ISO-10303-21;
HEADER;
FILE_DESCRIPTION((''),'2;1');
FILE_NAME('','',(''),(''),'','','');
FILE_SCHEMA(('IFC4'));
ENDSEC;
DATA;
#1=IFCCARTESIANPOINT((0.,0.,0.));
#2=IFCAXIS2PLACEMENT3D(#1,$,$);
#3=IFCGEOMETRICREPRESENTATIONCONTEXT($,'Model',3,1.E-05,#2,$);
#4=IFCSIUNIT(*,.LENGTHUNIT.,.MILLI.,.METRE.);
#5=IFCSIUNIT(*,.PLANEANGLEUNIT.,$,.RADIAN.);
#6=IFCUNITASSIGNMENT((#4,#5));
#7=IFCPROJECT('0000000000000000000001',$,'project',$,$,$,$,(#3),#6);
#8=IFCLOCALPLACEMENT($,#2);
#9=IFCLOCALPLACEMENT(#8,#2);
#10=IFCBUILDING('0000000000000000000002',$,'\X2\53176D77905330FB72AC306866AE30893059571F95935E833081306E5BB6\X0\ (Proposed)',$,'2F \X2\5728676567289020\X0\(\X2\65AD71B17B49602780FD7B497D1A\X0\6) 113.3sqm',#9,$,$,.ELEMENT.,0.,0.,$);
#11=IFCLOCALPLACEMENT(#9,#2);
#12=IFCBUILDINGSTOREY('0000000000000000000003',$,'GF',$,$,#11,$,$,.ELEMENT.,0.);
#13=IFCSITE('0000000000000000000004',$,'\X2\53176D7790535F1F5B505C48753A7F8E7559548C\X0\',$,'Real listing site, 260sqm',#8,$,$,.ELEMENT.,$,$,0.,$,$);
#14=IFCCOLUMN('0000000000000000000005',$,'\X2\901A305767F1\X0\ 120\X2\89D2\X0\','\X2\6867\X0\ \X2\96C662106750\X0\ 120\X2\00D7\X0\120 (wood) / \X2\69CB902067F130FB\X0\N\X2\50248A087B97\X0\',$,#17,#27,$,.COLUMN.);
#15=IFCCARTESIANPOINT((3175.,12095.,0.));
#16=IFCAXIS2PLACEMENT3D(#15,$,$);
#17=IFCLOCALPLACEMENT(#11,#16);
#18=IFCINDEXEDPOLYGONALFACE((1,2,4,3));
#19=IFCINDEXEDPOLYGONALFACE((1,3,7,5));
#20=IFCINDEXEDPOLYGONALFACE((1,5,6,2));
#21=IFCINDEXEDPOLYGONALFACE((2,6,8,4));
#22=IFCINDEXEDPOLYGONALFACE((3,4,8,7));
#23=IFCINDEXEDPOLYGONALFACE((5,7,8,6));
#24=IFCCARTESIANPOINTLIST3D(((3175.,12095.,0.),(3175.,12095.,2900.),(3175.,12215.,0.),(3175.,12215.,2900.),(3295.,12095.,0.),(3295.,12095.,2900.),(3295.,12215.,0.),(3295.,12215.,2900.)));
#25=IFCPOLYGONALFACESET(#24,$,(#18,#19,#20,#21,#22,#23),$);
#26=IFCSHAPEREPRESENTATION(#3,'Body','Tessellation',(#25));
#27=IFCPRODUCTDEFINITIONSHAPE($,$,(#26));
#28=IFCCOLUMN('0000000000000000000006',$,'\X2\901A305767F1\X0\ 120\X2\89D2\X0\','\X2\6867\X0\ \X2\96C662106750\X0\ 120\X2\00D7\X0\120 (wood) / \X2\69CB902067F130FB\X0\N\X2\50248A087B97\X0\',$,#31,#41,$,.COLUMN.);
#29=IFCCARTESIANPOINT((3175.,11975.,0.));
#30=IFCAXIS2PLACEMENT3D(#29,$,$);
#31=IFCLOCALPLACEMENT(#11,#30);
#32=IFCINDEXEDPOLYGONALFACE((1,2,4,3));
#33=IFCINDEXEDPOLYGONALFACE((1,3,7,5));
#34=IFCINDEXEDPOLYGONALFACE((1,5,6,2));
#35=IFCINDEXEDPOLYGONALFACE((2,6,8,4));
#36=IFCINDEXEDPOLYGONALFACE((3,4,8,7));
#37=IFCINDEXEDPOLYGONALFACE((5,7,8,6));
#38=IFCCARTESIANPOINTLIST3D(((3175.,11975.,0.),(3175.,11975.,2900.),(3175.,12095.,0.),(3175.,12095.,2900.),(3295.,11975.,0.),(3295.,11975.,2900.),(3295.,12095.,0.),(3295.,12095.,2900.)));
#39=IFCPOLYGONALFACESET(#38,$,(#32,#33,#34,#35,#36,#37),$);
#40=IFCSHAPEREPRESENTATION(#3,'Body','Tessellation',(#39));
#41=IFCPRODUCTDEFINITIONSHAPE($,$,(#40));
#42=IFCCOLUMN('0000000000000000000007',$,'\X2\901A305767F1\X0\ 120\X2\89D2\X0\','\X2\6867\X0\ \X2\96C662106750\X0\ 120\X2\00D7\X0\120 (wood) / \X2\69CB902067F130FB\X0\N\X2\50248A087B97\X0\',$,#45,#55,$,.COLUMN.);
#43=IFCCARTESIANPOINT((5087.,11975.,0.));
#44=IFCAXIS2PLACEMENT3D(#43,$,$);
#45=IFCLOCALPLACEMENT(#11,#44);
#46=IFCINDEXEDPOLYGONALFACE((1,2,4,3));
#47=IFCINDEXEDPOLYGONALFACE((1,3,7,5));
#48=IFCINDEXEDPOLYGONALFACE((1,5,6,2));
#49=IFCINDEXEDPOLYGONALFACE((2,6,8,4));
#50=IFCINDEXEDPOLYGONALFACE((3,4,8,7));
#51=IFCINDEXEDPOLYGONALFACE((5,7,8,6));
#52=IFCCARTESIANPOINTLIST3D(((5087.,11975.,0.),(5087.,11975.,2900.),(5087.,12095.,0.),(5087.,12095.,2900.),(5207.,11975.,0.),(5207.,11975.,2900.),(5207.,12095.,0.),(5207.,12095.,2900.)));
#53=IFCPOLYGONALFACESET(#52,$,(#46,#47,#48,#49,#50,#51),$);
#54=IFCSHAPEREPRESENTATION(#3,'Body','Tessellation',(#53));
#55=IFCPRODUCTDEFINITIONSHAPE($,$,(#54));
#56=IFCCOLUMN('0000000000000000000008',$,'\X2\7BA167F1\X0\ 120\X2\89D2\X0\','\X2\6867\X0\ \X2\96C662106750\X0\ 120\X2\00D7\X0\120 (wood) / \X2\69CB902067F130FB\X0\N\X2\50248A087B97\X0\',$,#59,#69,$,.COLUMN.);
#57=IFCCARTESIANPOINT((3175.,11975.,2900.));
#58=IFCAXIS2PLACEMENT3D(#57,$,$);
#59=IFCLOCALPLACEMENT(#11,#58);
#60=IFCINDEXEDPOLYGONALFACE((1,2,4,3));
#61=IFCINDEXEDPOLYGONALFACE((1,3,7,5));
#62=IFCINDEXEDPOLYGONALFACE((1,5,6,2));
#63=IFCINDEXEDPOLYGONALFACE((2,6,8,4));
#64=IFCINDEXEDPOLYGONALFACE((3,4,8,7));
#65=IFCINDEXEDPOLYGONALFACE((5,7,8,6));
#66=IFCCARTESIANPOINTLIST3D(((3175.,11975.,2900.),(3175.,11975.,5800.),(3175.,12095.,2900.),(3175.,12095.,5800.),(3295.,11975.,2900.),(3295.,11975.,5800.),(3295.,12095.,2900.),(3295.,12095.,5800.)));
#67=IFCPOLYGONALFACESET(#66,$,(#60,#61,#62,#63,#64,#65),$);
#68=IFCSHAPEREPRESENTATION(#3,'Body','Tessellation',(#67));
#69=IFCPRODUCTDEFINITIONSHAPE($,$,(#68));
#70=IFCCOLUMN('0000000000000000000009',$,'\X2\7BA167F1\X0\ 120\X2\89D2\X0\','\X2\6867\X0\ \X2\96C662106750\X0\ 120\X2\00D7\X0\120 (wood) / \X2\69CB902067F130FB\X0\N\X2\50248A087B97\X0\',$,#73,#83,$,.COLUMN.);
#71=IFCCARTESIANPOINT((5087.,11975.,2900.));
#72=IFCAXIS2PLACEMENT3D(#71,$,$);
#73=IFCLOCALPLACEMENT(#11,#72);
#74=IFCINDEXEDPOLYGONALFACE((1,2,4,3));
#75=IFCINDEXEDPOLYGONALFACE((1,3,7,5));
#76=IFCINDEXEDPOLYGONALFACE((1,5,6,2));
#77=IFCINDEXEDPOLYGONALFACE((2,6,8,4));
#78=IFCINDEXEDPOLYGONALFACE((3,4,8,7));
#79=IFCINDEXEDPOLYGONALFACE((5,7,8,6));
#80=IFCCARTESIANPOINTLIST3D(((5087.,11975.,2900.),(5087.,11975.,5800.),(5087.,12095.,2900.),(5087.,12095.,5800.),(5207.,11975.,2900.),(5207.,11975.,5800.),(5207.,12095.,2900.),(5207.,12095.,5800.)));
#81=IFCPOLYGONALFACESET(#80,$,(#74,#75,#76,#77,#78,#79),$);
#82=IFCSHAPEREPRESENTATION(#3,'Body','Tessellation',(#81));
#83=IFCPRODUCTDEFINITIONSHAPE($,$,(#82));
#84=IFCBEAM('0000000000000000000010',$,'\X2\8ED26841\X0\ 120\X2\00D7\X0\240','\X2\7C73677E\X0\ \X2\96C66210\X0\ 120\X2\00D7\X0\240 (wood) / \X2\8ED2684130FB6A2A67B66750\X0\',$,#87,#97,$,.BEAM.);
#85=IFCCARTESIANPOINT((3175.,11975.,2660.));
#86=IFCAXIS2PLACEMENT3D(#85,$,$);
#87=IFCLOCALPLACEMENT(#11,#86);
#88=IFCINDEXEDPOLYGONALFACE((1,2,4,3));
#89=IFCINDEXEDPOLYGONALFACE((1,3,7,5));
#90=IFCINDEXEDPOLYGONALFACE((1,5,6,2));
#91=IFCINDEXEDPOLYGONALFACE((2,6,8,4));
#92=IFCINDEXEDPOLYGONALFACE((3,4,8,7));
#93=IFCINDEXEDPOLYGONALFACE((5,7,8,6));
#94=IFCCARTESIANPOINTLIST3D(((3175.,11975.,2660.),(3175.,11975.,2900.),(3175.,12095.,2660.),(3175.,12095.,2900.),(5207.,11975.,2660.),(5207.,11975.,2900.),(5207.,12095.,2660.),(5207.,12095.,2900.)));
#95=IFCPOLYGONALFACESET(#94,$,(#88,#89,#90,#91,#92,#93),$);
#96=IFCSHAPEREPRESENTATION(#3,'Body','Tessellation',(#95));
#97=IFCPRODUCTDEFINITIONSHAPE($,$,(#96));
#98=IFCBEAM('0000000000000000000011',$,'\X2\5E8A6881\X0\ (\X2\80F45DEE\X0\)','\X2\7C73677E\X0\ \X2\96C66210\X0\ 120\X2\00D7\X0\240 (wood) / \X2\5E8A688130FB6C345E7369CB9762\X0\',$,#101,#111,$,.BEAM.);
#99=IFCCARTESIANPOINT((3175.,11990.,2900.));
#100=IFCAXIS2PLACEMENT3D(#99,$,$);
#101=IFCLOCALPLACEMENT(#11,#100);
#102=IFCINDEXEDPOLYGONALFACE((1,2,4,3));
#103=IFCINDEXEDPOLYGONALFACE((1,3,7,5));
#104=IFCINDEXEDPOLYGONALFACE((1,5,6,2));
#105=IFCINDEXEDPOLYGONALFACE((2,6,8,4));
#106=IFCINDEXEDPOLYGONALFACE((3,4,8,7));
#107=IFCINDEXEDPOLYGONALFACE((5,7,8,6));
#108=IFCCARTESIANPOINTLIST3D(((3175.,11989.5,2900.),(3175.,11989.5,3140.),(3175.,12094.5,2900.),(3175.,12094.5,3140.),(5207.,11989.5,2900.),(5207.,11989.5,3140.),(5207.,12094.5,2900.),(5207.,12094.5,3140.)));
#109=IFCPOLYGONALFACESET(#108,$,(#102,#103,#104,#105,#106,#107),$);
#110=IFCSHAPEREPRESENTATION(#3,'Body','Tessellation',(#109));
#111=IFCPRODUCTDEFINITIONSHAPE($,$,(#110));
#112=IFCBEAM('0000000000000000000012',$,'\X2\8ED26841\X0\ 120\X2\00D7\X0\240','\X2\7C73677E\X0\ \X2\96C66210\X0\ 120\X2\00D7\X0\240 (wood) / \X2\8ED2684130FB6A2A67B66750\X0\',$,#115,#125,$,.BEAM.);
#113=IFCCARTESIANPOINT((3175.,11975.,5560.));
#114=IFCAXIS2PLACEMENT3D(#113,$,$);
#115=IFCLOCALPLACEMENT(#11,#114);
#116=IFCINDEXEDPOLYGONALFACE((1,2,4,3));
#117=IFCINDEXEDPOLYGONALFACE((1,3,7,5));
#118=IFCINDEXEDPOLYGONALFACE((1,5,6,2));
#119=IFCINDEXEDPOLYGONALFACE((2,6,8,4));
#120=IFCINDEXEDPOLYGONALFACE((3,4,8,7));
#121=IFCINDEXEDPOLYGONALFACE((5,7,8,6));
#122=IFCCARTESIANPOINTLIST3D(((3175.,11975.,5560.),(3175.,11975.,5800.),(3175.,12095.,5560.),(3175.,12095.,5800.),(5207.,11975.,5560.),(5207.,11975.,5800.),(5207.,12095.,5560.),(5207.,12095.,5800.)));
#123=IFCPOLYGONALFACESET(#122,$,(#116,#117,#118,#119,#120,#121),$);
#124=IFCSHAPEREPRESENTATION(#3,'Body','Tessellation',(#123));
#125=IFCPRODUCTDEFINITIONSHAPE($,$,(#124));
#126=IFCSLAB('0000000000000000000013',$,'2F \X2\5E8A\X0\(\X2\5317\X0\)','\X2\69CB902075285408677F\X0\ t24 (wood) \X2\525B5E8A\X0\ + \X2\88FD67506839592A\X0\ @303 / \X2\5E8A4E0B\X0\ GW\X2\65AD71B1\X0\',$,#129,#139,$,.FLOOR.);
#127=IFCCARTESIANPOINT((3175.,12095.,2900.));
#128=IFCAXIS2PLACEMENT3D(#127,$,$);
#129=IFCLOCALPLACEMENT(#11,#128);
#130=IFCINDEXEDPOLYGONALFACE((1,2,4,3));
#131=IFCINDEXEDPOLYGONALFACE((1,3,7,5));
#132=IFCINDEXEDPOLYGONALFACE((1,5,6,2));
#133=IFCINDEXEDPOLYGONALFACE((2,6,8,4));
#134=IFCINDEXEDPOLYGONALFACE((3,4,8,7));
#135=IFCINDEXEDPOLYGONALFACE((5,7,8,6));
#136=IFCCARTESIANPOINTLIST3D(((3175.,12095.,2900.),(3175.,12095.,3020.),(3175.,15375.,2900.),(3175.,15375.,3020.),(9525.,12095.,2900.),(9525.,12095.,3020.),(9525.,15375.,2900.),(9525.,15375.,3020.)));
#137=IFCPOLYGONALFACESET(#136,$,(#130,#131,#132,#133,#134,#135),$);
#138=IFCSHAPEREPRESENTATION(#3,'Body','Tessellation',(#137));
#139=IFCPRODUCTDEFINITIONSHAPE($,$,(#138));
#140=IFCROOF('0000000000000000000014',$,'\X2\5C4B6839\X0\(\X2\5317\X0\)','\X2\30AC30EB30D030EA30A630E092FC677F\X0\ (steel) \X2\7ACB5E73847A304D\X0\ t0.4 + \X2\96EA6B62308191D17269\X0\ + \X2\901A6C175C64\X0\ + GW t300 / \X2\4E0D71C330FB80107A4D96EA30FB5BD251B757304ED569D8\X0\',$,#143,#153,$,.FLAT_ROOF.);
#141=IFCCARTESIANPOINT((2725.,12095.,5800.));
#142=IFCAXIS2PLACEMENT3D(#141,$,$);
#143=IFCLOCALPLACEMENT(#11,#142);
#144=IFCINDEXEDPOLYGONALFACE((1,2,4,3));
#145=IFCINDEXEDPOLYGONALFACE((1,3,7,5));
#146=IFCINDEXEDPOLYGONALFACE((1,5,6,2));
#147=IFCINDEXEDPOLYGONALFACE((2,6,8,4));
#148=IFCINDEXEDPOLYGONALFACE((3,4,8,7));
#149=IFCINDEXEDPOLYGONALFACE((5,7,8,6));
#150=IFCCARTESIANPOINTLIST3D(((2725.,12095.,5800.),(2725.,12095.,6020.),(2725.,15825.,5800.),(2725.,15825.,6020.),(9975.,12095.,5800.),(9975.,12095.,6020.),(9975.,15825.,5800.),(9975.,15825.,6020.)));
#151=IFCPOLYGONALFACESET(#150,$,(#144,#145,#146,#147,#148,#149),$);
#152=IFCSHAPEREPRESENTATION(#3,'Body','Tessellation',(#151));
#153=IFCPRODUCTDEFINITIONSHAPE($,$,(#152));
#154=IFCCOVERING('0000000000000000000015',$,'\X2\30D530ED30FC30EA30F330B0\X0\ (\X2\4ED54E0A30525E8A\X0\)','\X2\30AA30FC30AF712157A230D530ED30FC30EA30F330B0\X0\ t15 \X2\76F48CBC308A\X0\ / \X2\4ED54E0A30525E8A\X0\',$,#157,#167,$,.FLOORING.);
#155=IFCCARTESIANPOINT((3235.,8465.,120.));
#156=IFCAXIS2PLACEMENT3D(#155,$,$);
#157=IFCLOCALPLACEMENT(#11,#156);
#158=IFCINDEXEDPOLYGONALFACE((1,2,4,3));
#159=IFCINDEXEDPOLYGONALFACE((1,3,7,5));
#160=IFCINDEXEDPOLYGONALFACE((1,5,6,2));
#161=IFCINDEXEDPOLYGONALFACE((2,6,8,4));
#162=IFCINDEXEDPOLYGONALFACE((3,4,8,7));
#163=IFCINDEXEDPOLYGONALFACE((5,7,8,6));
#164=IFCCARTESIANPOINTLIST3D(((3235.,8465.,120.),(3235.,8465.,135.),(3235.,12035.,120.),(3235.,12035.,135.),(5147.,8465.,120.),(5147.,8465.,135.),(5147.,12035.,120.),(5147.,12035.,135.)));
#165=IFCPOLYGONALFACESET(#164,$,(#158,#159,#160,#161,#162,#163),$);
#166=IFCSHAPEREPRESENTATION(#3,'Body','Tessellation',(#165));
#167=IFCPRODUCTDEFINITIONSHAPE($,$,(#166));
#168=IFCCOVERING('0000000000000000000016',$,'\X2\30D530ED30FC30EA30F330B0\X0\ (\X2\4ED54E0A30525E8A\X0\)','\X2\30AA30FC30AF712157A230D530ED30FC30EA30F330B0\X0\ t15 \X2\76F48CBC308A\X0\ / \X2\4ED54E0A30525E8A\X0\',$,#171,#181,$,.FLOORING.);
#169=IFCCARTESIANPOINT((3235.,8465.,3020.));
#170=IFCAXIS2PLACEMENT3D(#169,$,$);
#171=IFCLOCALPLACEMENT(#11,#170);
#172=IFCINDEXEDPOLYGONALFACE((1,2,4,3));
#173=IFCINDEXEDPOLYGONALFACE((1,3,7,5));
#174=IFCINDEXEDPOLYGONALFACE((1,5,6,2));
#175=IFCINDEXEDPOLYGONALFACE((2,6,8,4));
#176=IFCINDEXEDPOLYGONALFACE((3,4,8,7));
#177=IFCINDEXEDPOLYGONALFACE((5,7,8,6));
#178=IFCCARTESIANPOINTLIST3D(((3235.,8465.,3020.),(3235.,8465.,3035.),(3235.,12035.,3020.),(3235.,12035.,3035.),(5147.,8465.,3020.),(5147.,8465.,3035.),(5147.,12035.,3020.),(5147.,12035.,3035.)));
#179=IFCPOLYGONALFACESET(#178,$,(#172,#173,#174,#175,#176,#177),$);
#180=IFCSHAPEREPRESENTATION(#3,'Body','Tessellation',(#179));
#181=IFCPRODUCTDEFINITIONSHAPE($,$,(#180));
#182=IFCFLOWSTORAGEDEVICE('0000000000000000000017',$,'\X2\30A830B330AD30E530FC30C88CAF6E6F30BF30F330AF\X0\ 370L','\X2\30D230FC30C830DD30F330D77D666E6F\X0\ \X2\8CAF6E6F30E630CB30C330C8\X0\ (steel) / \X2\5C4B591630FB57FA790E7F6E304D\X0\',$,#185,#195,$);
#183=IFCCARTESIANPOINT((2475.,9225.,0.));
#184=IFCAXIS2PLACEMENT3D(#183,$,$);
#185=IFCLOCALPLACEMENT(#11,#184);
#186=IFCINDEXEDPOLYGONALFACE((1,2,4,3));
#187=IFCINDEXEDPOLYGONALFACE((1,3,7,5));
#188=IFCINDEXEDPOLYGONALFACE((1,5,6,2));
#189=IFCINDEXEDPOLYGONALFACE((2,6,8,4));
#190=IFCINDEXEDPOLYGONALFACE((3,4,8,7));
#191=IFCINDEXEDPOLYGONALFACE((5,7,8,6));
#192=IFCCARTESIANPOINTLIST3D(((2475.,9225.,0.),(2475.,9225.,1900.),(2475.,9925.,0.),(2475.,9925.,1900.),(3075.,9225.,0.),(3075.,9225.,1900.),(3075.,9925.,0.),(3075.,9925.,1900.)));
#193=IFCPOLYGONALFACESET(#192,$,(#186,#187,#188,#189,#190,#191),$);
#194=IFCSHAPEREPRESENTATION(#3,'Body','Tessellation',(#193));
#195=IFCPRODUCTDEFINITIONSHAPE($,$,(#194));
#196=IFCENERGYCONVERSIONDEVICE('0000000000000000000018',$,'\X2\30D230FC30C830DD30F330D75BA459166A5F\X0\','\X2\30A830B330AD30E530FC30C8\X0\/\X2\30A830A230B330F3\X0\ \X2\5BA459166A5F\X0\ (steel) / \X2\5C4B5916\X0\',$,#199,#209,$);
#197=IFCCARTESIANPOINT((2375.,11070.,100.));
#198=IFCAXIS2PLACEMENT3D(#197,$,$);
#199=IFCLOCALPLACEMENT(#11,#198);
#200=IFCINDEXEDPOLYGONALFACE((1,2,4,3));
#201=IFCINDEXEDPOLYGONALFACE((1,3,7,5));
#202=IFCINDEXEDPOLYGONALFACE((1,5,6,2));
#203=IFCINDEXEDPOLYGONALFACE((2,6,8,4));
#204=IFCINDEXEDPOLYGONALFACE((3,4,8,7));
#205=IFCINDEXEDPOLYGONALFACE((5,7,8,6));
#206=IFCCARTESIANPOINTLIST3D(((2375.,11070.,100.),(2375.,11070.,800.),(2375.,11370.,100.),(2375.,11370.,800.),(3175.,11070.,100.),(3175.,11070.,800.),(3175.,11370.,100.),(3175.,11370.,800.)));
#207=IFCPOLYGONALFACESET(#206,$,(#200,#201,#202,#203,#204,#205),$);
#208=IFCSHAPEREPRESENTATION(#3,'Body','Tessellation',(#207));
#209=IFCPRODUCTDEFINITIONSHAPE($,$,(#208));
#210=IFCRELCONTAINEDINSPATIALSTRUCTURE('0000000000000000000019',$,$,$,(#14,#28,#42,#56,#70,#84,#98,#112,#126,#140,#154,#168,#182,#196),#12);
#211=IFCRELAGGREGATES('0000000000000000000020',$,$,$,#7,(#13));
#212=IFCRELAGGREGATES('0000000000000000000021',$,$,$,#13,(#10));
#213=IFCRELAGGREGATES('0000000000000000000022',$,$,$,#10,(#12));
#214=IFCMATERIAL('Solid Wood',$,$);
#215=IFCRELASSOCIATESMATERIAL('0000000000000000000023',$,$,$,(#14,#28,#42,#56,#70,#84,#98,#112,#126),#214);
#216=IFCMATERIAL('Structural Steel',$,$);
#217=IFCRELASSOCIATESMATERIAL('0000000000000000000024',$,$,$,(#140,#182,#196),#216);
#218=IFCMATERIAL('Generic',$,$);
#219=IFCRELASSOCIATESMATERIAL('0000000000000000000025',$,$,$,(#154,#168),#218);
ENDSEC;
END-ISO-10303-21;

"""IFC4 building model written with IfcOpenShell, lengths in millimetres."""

from ifc_helpers import new_model, si_unit, frame, frame_2d, origin, place, context, project, spatial, rectangle, extrude, material, element, save


model = new_model("IFC4")

# Units and contexts
model_context = context("Model", 3, precision=1e-05, world=origin())
ifc_project = project(units=[si_unit("LENGTHUNIT", "METRE", prefix="MILLI"), si_unit("PLANEANGLEUNIT", "RADIAN")], contexts=[model_context])

# Site, building, storey
site_placement = place(None, origin())
site = spatial("IfcSite", under=ifc_project, at=site_placement, Name="北海道弟子屈町美留和", ObjectType="Real listing site, 260sqm", CompositionType="ELEMENT", RefElevation=0.0)
building_placement = place(site_placement, origin())
building = spatial("IfcBuilding", under=site, at=building_placement, Name="北海道・犬と暮らす土間広めの家 (Proposed)", ObjectType="2F 在来木造(断熱等性能等級6) 113.3sqm", CompositionType="ELEMENT", ElevationOfRefHeight=0.0, ElevationOfTerrain=0.0)
storey_placement = place(building_placement, origin())
storey = spatial("IfcBuildingStorey", under=building, at=storey_placement, Name="GF", CompositionType="ELEMENT", Elevation=0.0)

# Columns
ifc_material_1 = material(Name="Solid Wood")
column_1_placement = place(storey_placement, frame((3175.0, 12095.0, 0.0)))
element("IfcColumn", 1, at=column_1_placement, inside=storey, material=ifc_material_1, Name="通し柱 120角", Description="桧 集成材 120×120 (wood) / 構造柱・N値計算", PredefinedType="COLUMN", context=model_context, shape_type="SweptSolid", body=[
    extrude(rectangle(XDim=120.0, YDim=120.0, at=frame_2d((60.0, 60.0))), frame((3175.0, 12095.0, 0.0)), (0.0, 0.0, 1.0), 2900.0),
])
column_2_placement = place(storey_placement, frame((3175.0, 11975.0, 0.0)))
element("IfcColumn", 2, at=column_2_placement, inside=storey, material=ifc_material_1, Name="通し柱 120角", Description="桧 集成材 120×120 (wood) / 構造柱・N値計算", PredefinedType="COLUMN", context=model_context, shape_type="SweptSolid", body=[
    extrude(rectangle(XDim=120.0, YDim=120.0, at=frame_2d((60.0, 60.0))), frame((3175.0, 11975.0, 0.0)), (0.0, 0.0, 1.0), 2900.0),
])
column_3_placement = place(storey_placement, frame((5087.0, 11975.0, 0.0)))
element("IfcColumn", 3, at=column_3_placement, inside=storey, material=ifc_material_1, Name="通し柱 120角", Description="桧 集成材 120×120 (wood) / 構造柱・N値計算", PredefinedType="COLUMN", context=model_context, shape_type="SweptSolid", body=[
    extrude(rectangle(XDim=120.0, YDim=120.0, at=frame_2d((60.0, 60.0))), frame((5087.0, 11975.0, 0.0)), (0.0, 0.0, 1.0), 2900.0),
])
column_4_placement = place(storey_placement, frame((3175.0, 11975.0, 2900.0)))
element("IfcColumn", 4, at=column_4_placement, inside=storey, material=ifc_material_1, Name="管柱 120角", Description="桧 集成材 120×120 (wood) / 構造柱・N値計算", PredefinedType="COLUMN", context=model_context, shape_type="SweptSolid", body=[
    extrude(rectangle(XDim=120.0, YDim=120.0, at=frame_2d((60.0, 60.0))), frame((3175.0, 11975.0, 2900.0)), (0.0, 0.0, 1.0), 2900.0),
])
column_5_placement = place(storey_placement, frame((5087.0, 11975.0, 2900.0)))
element("IfcColumn", 5, at=column_5_placement, inside=storey, material=ifc_material_1, Name="管柱 120角", Description="桧 集成材 120×120 (wood) / 構造柱・N値計算", PredefinedType="COLUMN", context=model_context, shape_type="SweptSolid", body=[
    extrude(rectangle(XDim=120.0, YDim=120.0, at=frame_2d((60.0, 60.0))), frame((5087.0, 11975.0, 2900.0)), (0.0, 0.0, 1.0), 2900.0),
])

# Beams
beam_1_placement = place(storey_placement, frame((3175.0, 11975.0, 2660.0)))
element("IfcBeam", 6, at=beam_1_placement, inside=storey, material=ifc_material_1, Name="軒桁 120×240", Description="米松 集成 120×240 (wood) / 軒桁・横架材", PredefinedType="BEAM", context=model_context, shape_type="SweptSolid", body=[
    extrude(rectangle(XDim=2032.0, YDim=120.0, at=frame_2d((1016.0, 60.0))), frame((3175.0, 11975.0, 2660.0)), (0.0, 0.0, 1.0), 240.0),
])
beam_2_placement = place(storey_placement, frame((3175.0, 11990.0, 2900.0)))
element("IfcBeam", 7, at=beam_2_placement, inside=storey, material=ifc_material_1, Name="床梁 (胴差)", Description="米松 集成 120×240 (wood) / 床梁・水平構面", PredefinedType="BEAM", context=model_context, shape_type="SweptSolid", body=[
    extrude(rectangle(XDim=2032.0, YDim=105.0, at=frame_2d((1016.0, 52.0))), frame((3175.0, 11990.0, 2900.0)), (0.0, 0.0, 1.0), 240.0),
])
beam_3_placement = place(storey_placement, frame((3175.0, 11975.0, 5560.0)))
element("IfcBeam", 8, at=beam_3_placement, inside=storey, material=ifc_material_1, Name="軒桁 120×240", Description="米松 集成 120×240 (wood) / 軒桁・横架材", PredefinedType="BEAM", context=model_context, shape_type="SweptSolid", body=[
    extrude(rectangle(XDim=2032.0, YDim=120.0, at=frame_2d((1016.0, 60.0))), frame((3175.0, 11975.0, 5560.0)), (0.0, 0.0, 1.0), 240.0),
])

# Slab
slab_1_placement = place(storey_placement, frame((3175.0, 12095.0, 2900.0)))
element("IfcSlab", 9, at=slab_1_placement, inside=storey, material=ifc_material_1, Name="2F 床(北)", Description="構造用合板 t24 (wood) 剛床 + 製材根太 @303 / 床下 GW断熱", PredefinedType="FLOOR", context=model_context, shape_type="SweptSolid", body=[
    extrude(rectangle(XDim=6350.0, YDim=3280.0, at=frame_2d((3175.0, 1640.0))), frame((3175.0, 12095.0, 2900.0)), (0.0, 0.0, 1.0), 120.0),
])

# Roof
ifc_material_2 = material(Name="Structural Steel")
for number, where, name in (
    (10, (2725.0, 12095.0, 5800.0), "屋根(北)"),
):
    element("IfcRoof", number, at=place(storey_placement, frame(where)), inside=storey, material=ifc_material_2, Name=name, Description="ガルバリウム鋼板 (steel) 立平葺き t0.4 + 雪止め金物 + 通気層 + GW t300 / 不燃・耐積雪・寒冷地仕様", PredefinedType="FLAT_ROOF", context=model_context, shape_type="SweptSolid", body=[
        extrude(rectangle(XDim=7250.0, YDim=3730.0, at=frame_2d((3625.0, 1865.0))), frame((2725.0, 12095.0, 5800.0)), (0.0, 0.0, 1.0), 220.0),
    ])

# Coverings
ifc_material_3 = material(Name="Generic")
covering_1_placement = place(storey_placement, frame((3235.0, 8465.0, 120.0)))
element("IfcCovering", 11, at=covering_1_placement, inside=storey, material=ifc_material_3, Name="フローリング (仕上げ床)", Description="オーク無垢フローリング t15 直貼り / 仕上げ床", PredefinedType="FLOORING", context=model_context, shape_type="SweptSolid", body=[
    extrude(rectangle(XDim=1912.0, YDim=3570.0, at=frame_2d((956.0, 1785.0))), frame((3235.0, 8465.0, 120.0)), (0.0, 0.0, 1.0), 15.0),
])
covering_2_placement = place(storey_placement, frame((3235.0, 8465.0, 3020.0)))
element("IfcCovering", 12, at=covering_2_placement, inside=storey, material=ifc_material_3, Name="フローリング (仕上げ床)", Description="オーク無垢フローリング t15 直貼り / 仕上げ床", PredefinedType="FLOORING", context=model_context, shape_type="SweptSolid", body=[
    extrude(rectangle(XDim=1912.0, YDim=3570.0, at=frame_2d((956.0, 1785.0))), frame((3235.0, 8465.0, 3020.0)), (0.0, 0.0, 1.0), 15.0),
])

# Flow storage device
flow_storage_device_placement = place(storey_placement, frame((2475.0, 9225.0, 0.0)))
element("IfcFlowStorageDevice", 13, at=flow_storage_device_placement, inside=storey, material=ifc_material_2, Name="エコキュート貯湯タンク 370L", Description="ヒートポンプ給湯 貯湯ユニット (steel) / 屋外・基礎置き", context=model_context, shape_type="SweptSolid", body=[
    extrude(rectangle(XDim=600.0, YDim=700.0, at=frame_2d((300.0, 350.0))), frame((2475.0, 9225.0, 0.0)), (0.0, 0.0, 1.0), 1900.0),
])

# Energy conversion device
energy_conversion_device_placement = place(storey_placement, frame((2375.0, 11070.0, 100.0)))
element("IfcEnergyConversionDevice", 14, at=energy_conversion_device_placement, inside=storey, material=ifc_material_2, Name="ヒートポンプ室外機", Description="エコキュート/エアコン 室外機 (steel) / 屋外", context=model_context, shape_type="SweptSolid", body=[
    extrude(rectangle(XDim=800.0, YDim=300.0, at=frame_2d((400.0, 150.0))), frame((2375.0, 11070.0, 100.0)), (0.0, 0.0, 1.0), 700.0),
])

save(model, "model.ifc")
